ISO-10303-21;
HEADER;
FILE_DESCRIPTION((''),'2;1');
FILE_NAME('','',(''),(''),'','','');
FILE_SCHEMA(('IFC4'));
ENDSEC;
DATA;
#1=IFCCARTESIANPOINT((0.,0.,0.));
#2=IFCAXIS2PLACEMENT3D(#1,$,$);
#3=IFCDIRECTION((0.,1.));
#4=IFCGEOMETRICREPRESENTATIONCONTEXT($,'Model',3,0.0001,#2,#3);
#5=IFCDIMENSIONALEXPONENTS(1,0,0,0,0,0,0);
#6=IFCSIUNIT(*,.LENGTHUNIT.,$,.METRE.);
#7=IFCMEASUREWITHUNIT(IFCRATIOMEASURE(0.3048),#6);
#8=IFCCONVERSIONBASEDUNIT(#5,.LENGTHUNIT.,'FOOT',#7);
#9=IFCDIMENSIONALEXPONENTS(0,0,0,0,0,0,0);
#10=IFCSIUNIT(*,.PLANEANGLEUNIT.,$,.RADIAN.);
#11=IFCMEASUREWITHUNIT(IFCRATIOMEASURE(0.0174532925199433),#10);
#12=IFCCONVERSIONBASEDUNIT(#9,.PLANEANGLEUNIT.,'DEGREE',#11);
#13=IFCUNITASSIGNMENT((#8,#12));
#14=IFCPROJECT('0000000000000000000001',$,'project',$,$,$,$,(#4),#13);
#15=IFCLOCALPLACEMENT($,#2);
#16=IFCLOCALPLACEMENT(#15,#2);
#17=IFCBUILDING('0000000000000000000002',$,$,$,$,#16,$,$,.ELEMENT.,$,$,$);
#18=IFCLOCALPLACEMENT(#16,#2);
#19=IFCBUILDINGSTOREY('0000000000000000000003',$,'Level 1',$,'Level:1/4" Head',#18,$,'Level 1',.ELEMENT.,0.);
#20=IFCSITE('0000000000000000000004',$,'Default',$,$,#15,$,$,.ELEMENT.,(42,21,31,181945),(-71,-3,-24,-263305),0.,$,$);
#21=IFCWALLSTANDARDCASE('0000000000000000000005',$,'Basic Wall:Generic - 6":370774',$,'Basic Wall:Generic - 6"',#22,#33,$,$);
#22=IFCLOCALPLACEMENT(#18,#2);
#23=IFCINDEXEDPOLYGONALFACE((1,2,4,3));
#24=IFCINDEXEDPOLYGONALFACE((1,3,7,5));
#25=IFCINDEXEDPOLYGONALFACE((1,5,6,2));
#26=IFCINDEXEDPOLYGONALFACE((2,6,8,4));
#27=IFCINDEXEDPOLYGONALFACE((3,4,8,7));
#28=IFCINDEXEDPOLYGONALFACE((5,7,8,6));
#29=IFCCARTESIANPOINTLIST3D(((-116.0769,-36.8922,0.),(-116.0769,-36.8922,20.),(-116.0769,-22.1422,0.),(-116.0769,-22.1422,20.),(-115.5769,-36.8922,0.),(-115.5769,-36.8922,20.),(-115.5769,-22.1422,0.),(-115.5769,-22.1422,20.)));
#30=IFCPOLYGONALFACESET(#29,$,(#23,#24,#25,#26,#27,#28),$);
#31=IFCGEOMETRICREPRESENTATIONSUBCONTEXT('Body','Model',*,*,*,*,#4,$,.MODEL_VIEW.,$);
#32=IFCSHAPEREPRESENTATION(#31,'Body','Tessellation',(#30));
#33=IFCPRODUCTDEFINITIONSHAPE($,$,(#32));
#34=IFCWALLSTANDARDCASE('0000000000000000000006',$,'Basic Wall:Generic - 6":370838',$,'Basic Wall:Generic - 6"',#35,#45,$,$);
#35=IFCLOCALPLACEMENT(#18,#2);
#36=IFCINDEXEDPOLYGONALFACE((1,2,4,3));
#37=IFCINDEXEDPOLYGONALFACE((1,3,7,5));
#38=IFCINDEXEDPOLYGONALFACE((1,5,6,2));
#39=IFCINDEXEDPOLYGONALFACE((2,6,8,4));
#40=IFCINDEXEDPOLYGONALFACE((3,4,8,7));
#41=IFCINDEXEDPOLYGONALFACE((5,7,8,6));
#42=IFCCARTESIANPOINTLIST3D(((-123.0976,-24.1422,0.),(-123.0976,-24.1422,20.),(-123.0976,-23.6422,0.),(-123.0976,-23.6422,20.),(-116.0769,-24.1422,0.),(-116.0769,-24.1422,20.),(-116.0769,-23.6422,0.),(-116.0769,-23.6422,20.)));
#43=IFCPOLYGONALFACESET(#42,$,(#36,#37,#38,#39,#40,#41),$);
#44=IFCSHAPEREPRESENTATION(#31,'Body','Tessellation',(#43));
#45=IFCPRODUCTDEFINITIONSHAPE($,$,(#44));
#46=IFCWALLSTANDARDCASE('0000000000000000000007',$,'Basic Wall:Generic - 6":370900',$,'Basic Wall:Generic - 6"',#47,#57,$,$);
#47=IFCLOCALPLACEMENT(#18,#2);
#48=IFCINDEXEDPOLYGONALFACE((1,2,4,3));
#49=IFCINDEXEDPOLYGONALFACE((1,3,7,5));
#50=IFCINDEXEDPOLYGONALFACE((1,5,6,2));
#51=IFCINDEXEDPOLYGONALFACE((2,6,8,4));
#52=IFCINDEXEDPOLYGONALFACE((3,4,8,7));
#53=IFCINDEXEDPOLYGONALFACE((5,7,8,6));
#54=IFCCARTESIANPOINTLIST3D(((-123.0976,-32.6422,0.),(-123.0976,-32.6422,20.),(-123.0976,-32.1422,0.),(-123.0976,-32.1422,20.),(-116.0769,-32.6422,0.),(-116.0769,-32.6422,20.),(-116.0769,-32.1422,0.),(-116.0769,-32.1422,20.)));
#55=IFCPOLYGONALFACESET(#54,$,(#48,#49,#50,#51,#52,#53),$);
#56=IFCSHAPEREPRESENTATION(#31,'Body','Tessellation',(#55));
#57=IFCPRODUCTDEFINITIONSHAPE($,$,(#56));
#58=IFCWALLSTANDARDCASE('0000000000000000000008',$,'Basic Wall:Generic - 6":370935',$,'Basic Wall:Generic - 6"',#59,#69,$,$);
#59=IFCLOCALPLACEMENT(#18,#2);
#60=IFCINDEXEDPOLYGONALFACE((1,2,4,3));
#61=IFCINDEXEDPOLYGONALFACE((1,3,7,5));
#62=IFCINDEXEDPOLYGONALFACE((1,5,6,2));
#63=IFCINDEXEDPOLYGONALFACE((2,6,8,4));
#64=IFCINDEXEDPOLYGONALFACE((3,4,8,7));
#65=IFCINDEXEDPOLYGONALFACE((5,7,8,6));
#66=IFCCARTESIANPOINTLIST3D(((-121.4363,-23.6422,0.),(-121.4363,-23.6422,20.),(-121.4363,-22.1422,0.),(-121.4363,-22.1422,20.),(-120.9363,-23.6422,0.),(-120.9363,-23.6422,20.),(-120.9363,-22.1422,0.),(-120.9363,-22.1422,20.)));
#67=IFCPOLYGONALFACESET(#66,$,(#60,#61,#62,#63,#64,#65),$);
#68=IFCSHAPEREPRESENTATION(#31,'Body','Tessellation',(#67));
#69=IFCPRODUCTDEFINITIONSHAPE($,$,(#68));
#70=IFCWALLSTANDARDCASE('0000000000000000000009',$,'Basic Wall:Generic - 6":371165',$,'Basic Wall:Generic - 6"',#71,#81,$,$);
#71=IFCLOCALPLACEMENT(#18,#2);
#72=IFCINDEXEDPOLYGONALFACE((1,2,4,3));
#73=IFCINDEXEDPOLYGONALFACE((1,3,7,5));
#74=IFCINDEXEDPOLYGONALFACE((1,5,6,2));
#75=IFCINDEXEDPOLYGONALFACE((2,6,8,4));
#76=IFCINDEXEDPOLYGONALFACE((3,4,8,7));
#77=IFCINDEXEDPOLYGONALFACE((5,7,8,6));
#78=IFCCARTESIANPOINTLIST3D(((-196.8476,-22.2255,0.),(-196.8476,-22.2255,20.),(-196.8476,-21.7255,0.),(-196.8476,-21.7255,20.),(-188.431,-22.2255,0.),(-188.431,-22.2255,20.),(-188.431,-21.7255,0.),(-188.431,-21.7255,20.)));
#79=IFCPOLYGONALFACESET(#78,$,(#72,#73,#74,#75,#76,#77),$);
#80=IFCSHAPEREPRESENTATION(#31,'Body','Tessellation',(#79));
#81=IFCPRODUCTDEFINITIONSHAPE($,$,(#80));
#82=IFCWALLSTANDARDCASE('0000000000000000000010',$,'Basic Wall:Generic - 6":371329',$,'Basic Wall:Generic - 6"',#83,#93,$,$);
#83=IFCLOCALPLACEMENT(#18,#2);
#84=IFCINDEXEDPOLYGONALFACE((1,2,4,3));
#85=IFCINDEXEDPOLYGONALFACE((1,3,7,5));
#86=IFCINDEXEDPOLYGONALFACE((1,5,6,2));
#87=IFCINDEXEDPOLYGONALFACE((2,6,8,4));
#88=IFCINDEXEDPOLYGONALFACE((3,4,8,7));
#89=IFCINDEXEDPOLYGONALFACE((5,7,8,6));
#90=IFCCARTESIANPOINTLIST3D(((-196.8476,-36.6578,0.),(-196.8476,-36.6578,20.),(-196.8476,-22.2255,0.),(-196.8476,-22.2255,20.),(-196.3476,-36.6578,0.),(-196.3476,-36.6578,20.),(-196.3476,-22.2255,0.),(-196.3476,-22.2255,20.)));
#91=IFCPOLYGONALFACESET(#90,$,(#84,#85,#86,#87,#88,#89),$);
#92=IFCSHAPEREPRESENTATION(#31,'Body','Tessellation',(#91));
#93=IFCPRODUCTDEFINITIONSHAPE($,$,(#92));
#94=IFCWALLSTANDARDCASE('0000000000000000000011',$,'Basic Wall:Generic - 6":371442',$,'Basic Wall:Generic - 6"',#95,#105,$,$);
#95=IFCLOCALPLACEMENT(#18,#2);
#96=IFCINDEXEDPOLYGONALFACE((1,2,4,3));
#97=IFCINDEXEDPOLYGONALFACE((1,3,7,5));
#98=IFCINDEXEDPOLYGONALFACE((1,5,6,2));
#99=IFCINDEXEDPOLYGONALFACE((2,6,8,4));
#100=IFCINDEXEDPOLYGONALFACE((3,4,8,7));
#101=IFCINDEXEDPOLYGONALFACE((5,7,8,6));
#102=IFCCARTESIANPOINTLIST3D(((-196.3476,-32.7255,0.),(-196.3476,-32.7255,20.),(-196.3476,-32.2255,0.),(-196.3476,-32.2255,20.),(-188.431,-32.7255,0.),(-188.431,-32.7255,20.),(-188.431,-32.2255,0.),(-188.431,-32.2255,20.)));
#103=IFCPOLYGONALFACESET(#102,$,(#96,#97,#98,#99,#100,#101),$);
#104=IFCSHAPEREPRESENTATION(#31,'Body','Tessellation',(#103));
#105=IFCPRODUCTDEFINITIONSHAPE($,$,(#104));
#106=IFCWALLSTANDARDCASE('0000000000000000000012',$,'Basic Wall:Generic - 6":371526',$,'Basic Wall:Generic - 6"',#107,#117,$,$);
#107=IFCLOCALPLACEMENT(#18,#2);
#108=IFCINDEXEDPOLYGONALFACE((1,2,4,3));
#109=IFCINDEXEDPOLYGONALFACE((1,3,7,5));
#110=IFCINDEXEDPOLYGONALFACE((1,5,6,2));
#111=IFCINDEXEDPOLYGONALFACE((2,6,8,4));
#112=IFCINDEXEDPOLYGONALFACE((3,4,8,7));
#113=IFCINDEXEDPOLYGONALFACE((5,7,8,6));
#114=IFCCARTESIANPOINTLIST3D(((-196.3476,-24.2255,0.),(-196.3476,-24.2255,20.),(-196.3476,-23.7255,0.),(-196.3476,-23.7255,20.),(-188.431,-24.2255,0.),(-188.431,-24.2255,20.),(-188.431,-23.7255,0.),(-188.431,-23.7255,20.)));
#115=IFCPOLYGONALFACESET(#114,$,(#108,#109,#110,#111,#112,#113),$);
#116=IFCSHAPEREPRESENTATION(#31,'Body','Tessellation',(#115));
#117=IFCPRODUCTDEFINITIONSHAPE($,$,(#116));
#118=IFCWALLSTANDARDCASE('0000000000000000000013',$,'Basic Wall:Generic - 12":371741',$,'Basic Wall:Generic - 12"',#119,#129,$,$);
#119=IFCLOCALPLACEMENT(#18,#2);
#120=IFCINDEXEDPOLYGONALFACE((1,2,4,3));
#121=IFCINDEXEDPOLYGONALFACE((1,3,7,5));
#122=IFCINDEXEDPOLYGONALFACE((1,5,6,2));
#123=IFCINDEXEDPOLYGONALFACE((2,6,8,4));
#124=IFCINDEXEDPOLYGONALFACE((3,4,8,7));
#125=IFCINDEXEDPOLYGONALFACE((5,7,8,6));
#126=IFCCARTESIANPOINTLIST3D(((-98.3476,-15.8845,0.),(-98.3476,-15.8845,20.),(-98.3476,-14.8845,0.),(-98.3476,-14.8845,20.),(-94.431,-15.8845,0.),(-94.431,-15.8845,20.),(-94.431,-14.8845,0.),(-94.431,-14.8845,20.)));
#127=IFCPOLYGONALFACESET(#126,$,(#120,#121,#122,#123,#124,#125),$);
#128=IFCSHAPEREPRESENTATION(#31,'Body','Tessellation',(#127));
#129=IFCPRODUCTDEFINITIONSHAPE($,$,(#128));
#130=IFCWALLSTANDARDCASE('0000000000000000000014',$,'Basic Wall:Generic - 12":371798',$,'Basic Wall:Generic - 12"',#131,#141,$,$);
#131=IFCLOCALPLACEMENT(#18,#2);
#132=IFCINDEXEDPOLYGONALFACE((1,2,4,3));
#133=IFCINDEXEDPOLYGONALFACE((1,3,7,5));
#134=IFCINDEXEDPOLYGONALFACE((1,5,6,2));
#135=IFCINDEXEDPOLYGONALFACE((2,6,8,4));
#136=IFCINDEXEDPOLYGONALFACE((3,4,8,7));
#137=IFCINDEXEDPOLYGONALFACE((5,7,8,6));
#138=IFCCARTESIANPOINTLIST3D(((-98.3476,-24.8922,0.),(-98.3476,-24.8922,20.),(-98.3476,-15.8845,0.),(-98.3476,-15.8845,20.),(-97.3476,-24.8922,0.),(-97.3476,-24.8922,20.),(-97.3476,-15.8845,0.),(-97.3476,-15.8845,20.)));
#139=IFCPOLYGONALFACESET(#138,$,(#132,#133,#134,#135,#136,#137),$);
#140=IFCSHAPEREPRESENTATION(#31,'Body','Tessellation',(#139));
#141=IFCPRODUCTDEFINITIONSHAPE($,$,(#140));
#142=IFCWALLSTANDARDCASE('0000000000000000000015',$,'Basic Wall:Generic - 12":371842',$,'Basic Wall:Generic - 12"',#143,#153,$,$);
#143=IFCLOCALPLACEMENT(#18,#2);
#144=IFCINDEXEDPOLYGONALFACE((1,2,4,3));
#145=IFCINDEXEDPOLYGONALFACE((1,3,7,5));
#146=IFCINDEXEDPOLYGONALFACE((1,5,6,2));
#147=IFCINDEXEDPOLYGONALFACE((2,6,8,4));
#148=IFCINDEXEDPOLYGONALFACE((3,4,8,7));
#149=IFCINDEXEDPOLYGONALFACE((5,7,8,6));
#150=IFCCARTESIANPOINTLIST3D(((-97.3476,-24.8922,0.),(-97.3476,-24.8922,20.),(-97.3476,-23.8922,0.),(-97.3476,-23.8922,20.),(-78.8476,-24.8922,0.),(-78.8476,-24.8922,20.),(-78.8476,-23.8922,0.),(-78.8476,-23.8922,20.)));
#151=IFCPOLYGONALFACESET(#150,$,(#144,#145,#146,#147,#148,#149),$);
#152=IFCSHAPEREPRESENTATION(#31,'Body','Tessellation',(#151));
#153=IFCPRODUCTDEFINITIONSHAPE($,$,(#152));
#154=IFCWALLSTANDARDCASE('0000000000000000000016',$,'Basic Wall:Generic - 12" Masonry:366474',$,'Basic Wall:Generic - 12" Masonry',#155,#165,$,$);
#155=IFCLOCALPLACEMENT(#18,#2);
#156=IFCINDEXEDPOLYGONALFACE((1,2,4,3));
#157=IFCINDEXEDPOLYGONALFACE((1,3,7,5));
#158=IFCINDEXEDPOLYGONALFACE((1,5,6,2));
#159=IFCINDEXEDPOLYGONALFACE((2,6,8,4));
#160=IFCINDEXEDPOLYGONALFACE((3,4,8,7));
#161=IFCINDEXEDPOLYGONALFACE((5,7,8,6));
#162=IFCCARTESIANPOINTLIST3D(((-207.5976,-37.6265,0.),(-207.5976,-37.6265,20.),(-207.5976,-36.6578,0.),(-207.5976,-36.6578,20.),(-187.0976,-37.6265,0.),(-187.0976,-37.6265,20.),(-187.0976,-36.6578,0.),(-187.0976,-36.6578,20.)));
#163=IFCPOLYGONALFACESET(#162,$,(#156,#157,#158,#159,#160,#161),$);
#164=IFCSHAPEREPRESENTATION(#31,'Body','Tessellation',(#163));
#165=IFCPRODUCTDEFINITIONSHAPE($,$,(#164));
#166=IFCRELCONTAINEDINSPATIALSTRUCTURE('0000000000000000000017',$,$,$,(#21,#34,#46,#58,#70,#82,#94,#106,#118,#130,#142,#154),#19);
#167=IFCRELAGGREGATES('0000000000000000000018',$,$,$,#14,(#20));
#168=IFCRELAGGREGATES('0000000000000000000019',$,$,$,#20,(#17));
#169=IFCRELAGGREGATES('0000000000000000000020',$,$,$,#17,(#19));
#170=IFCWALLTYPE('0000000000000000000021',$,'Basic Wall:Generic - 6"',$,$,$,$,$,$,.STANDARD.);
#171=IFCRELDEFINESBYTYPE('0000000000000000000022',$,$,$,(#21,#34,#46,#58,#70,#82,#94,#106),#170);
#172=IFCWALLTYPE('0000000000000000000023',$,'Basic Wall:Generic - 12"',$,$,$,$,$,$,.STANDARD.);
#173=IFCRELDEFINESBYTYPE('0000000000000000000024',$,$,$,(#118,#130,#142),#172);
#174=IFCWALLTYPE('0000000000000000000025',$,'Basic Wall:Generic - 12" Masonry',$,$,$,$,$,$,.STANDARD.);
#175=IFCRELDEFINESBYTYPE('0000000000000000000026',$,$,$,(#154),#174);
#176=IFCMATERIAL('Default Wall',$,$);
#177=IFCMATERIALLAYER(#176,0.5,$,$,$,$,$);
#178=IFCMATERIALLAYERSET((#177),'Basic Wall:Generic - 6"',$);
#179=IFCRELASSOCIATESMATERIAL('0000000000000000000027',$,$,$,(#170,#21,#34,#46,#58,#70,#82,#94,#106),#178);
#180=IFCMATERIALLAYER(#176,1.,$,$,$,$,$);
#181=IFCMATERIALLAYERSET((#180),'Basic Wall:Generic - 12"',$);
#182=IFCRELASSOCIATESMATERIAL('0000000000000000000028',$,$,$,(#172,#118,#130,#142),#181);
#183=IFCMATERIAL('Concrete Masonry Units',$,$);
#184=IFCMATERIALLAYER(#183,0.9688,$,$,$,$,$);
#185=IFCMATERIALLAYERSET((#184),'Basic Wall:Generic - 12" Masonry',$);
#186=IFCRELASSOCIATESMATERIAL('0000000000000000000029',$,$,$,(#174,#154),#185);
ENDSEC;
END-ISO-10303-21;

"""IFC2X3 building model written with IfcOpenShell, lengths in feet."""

from ifc_helpers import new_model, entity, si_unit, converted_unit, direction, frame, frame_2d, origin, place, context, subcontext, project, spatial, rectangle, extrude, material, layer, layer_set, layer_usage, type_object, element, save


model = new_model("IFC2X3")

# Units and contexts
model_context = context("Model", 3, precision=0.0001, world=origin(), true_north=direction((0.0, 1.0)))
body_context = subcontext(model_context, "Body", "Model", "MODEL_VIEW")
ifc_project = project(units=[converted_unit("LENGTHUNIT", "FOOT", entity("IfcRatioMeasure", 0.3048), si_unit("LENGTHUNIT", "METRE"), dimensions=[1, 0, 0, 0, 0, 0, 0]), converted_unit("PLANEANGLEUNIT", "DEGREE", entity("IfcRatioMeasure", 0.0174532925199433), si_unit("PLANEANGLEUNIT", "RADIAN"), dimensions=[0, 0, 0, 0, 0, 0, 0])], contexts=[model_context])

# Site, building, storey
site_placement = place(None, origin())
site = spatial("IfcSite", under=ifc_project, at=site_placement, Name="Default", CompositionType="ELEMENT", RefLatitude=(42, 21, 31, 181945), RefLongitude=(-71, -3, -24, -263305), RefElevation=0.0)
building_placement = place(site_placement, origin())
building = spatial("IfcBuilding", under=site, at=building_placement, CompositionType="ELEMENT")
storey_placement = place(building_placement, origin())
storey = spatial("IfcBuildingStorey", under=building, at=storey_placement, Name="Level 1", ObjectType="Level:1/4\" Head", LongName="Level 1", CompositionType="ELEMENT", Elevation=0.0)

# Walls
ifc_material_1 = material(Name="Default Wall")
ifc_layer_1 = layer(ifc_material_1, 0.5)
ifc_layer_set_1 = layer_set([ifc_layer_1], Name="Basic Wall:Generic - 6\"")
wall_type_1 = type_object("IfcWallType", Name="Basic Wall:Generic - 6\"", PredefinedType="STANDARD", material=ifc_layer_set_1)
ifc_layer_usage_1 = layer_usage(ifc_layer_set_1, "AXIS2", "NEGATIVE", 0.25)
wall_1_placement = place(storey_placement, frame((-115.8269, -22.1422, 0.0), z_axis=(0.0, 0.0, 1.0), x_axis=(0.0, -1.0, 0.0)))
element("IfcWallStandardCase", 1, at=wall_1_placement, inside=storey, type_object=wall_type_1, material=ifc_layer_usage_1, Name="Basic Wall:Generic - 6\":370774", ObjectType="Basic Wall:Generic - 6\"", context=body_context, shape_type="SweptSolid", body=[
    extrude(rectangle(XDim=14.75, YDim=0.5, at=frame_2d((7.375, 0.0), x_axis=(-1.0, 0.0))), origin(), (0.0, 0.0, 1.0), 20.0),
])
ifc_layer_usage_2 = layer_usage(ifc_layer_set_1, "AXIS2", "NEGATIVE", 0.25)
wall_2_placement = place(storey_placement, frame((-123.0976, -23.8922, 0.0)))
element("IfcWallStandardCase", 2, at=wall_2_placement, inside=storey, type_object=wall_type_1, material=ifc_layer_usage_2, Name="Basic Wall:Generic - 6\":370838", ObjectType="Basic Wall:Generic - 6\"", context=body_context, shape_type="SweptSolid", body=[
    extrude(rectangle(XDim=7.0208, YDim=0.5, at=frame_2d((3.5104, 0.0), x_axis=(-1.0, 0.0))), origin(), (0.0, 0.0, 1.0), 20.0),
])
ifc_layer_usage_3 = layer_usage(ifc_layer_set_1, "AXIS2", "NEGATIVE", 0.25)
wall_3_placement = place(storey_placement, frame((-123.0976, -32.3922, 0.0)))
element("IfcWallStandardCase", 3, at=wall_3_placement, inside=storey, type_object=wall_type_1, material=ifc_layer_usage_3, Name="Basic Wall:Generic - 6\":370900", ObjectType="Basic Wall:Generic - 6\"", context=body_context, shape_type="SweptSolid", body=[
    extrude(rectangle(XDim=7.0208, YDim=0.5, at=frame_2d((3.5104, 0.0), x_axis=(-1.0, 0.0))), origin(), (0.0, 0.0, 1.0), 20.0),
])
ifc_layer_usage_4 = layer_usage(ifc_layer_set_1, "AXIS2", "NEGATIVE", 0.25)
wall_4_placement = place(storey_placement, frame((-121.1863, -22.1422, 0.0), z_axis=(0.0, 0.0, 1.0), x_axis=(0.0, -1.0, 0.0)))
element("IfcWallStandardCase", 4, at=wall_4_placement, inside=storey, type_object=wall_type_1, material=ifc_layer_usage_4, Name="Basic Wall:Generic - 6\":370935", ObjectType="Basic Wall:Generic - 6\"", context=body_context, shape_type="SweptSolid", body=[
    extrude(rectangle(XDim=1.5, YDim=0.5, at=frame_2d((0.75, 0.0), x_axis=(-1.0, 0.0))), origin(), (0.0, 0.0, 1.0), 20.0),
])
ifc_layer_usage_5 = layer_usage(ifc_layer_set_1, "AXIS2", "NEGATIVE", 0.25)
wall_5_placement = place(storey_placement, frame((-188.431, -21.9755, 0.0), z_axis=(0.0, 0.0, 1.0), x_axis=(-1.0, 0.0, 0.0)))
element("IfcWallStandardCase", 5, at=wall_5_placement, inside=storey, type_object=wall_type_1, material=ifc_layer_usage_5, Name="Basic Wall:Generic - 6\":371165", ObjectType="Basic Wall:Generic - 6\"", context=body_context, shape_type="SweptSolid", body=[
    extrude(rectangle(XDim=8.4167, YDim=0.5, at=frame_2d((4.2083, 0.0), x_axis=(-1.0, 0.0))), origin(), (0.0, 0.0, 1.0), 20.0),
])
ifc_layer_usage_6 = layer_usage(ifc_layer_set_1, "AXIS2", "NEGATIVE", 0.25)
wall_6_placement = place(storey_placement, frame((-196.5976, -22.2255, 0.0), z_axis=(0.0, 0.0, 1.0), x_axis=(0.0, -1.0, 0.0)))
element("IfcWallStandardCase", 6, at=wall_6_placement, inside=storey, type_object=wall_type_1, material=ifc_layer_usage_6, Name="Basic Wall:Generic - 6\":371329", ObjectType="Basic Wall:Generic - 6\"", context=body_context, shape_type="SweptSolid", body=[
    extrude(rectangle(XDim=14.4323, YDim=0.5, at=frame_2d((7.2161, 0.0), x_axis=(-1.0, 0.0))), origin(), (0.0, 0.0, 1.0), 20.0),
])
ifc_layer_usage_7 = layer_usage(ifc_layer_set_1, "AXIS2", "NEGATIVE", 0.25)
wall_7_placement = place(storey_placement, frame((-188.431, -32.4755, 0.0), z_axis=(0.0, 0.0, 1.0), x_axis=(-1.0, 0.0, 0.0)))
element("IfcWallStandardCase", 7, at=wall_7_placement, inside=storey, type_object=wall_type_1, material=ifc_layer_usage_7, Name="Basic Wall:Generic - 6\":371442", ObjectType="Basic Wall:Generic - 6\"", context=body_context, shape_type="SweptSolid", body=[
    extrude(rectangle(XDim=7.9167, YDim=0.5, at=frame_2d((3.9583, 0.0), x_axis=(-1.0, 0.0))), origin(), (0.0, 0.0, 1.0), 20.0),
])
ifc_layer_usage_8 = layer_usage(ifc_layer_set_1, "AXIS2", "NEGATIVE", 0.25)
wall_8_placement = place(storey_placement, frame((-188.431, -23.9755, 0.0), z_axis=(0.0, 0.0, 1.0), x_axis=(-1.0, 0.0, 0.0)))
element("IfcWallStandardCase", 8, at=wall_8_placement, inside=storey, type_object=wall_type_1, material=ifc_layer_usage_8, Name="Basic Wall:Generic - 6\":371526", ObjectType="Basic Wall:Generic - 6\"", context=body_context, shape_type="SweptSolid", body=[
    extrude(rectangle(XDim=7.9167, YDim=0.5, at=frame_2d((3.9583, 0.0), x_axis=(-1.0, 0.0))), origin(), (0.0, 0.0, 1.0), 20.0),
])
ifc_layer_2 = layer(ifc_material_1, 1.0)
ifc_layer_set_2 = layer_set([ifc_layer_2], Name="Basic Wall:Generic - 12\"")
ifc_layer_usage_9 = layer_usage(ifc_layer_set_2, "AXIS2", "NEGATIVE", 0.5)
wall_type_2 = type_object("IfcWallType", Name="Basic Wall:Generic - 12\"", PredefinedType="STANDARD", material=ifc_layer_set_2)
wall_9_placement = place(storey_placement, frame((-94.431, -15.3845, 0.0), z_axis=(0.0, 0.0, 1.0), x_axis=(-1.0, 0.0, 0.0)))
element("IfcWallStandardCase", 9, at=wall_9_placement, inside=storey, type_object=wall_type_2, material=ifc_layer_usage_9, Name="Basic Wall:Generic - 12\":371741", ObjectType="Basic Wall:Generic - 12\"", context=body_context, shape_type="SweptSolid", body=[
    extrude(rectangle(XDim=3.9167, YDim=1.0, at=frame_2d((1.9583, 0.0), x_axis=(-1.0, 0.0))), origin(), (0.0, 0.0, 1.0), 20.0),
])
ifc_layer_usage_10 = layer_usage(ifc_layer_set_2, "AXIS2", "NEGATIVE", 0.5)
wall_10_placement = place(storey_placement, frame((-97.8476, -15.8845, 0.0), z_axis=(0.0, 0.0, 1.0), x_axis=(0.0, -1.0, 0.0)))
element("IfcWallStandardCase", 10, at=wall_10_placement, inside=storey, type_object=wall_type_2, material=ifc_layer_usage_10, Name="Basic Wall:Generic - 12\":371798", ObjectType="Basic Wall:Generic - 12\"", context=body_context, shape_type="SweptSolid", body=[
    extrude(rectangle(XDim=9.0076, YDim=1.0, at=frame_2d((4.5038, 0.0), x_axis=(-1.0, 0.0))), origin(), (0.0, 0.0, 1.0), 20.0),
])
ifc_layer_usage_11 = layer_usage(ifc_layer_set_2, "AXIS2", "NEGATIVE", 0.5)
wall_11_placement = place(storey_placement, frame((-97.3476, -24.3922, 0.0)))
element("IfcWallStandardCase", 11, at=wall_11_placement, inside=storey, type_object=wall_type_2, material=ifc_layer_usage_11, Name="Basic Wall:Generic - 12\":371842", ObjectType="Basic Wall:Generic - 12\"", context=body_context, shape_type="SweptSolid", body=[
    extrude(rectangle(XDim=18.5, YDim=1.0, at=frame_2d((9.25, 0.0), x_axis=(-1.0, 0.0))), origin(), (0.0, 0.0, 1.0), 20.0),
])
ifc_material_2 = material(Name="Concrete Masonry Units")
ifc_layer_3 = layer(ifc_material_2, 0.9688)
ifc_layer_set_3 = layer_set([ifc_layer_3], Name="Basic Wall:Generic - 12\" Masonry")
ifc_layer_usage_12 = layer_usage(ifc_layer_set_3, "AXIS2", "NEGATIVE", 0.4844)
wall_type_3 = type_object("IfcWallType", Name="Basic Wall:Generic - 12\" Masonry", PredefinedType="STANDARD", material=ifc_layer_set_3)
wall_12_placement = place(storey_placement, frame((-207.5976, -37.1422, 0.0)))
element("IfcWallStandardCase", 12, at=wall_12_placement, inside=storey, type_object=wall_type_3, material=ifc_layer_usage_12, Name="Basic Wall:Generic - 12\" Masonry:366474", ObjectType="Basic Wall:Generic - 12\" Masonry", context=body_context, shape_type="SweptSolid", body=[
    extrude(rectangle(XDim=20.5, YDim=0.9688, at=frame_2d((10.25, 0.0), x_axis=(-1.0, 0.0))), origin(), (0.0, 0.0, 1.0), 20.0),
])

save(model, "model.ifc")
